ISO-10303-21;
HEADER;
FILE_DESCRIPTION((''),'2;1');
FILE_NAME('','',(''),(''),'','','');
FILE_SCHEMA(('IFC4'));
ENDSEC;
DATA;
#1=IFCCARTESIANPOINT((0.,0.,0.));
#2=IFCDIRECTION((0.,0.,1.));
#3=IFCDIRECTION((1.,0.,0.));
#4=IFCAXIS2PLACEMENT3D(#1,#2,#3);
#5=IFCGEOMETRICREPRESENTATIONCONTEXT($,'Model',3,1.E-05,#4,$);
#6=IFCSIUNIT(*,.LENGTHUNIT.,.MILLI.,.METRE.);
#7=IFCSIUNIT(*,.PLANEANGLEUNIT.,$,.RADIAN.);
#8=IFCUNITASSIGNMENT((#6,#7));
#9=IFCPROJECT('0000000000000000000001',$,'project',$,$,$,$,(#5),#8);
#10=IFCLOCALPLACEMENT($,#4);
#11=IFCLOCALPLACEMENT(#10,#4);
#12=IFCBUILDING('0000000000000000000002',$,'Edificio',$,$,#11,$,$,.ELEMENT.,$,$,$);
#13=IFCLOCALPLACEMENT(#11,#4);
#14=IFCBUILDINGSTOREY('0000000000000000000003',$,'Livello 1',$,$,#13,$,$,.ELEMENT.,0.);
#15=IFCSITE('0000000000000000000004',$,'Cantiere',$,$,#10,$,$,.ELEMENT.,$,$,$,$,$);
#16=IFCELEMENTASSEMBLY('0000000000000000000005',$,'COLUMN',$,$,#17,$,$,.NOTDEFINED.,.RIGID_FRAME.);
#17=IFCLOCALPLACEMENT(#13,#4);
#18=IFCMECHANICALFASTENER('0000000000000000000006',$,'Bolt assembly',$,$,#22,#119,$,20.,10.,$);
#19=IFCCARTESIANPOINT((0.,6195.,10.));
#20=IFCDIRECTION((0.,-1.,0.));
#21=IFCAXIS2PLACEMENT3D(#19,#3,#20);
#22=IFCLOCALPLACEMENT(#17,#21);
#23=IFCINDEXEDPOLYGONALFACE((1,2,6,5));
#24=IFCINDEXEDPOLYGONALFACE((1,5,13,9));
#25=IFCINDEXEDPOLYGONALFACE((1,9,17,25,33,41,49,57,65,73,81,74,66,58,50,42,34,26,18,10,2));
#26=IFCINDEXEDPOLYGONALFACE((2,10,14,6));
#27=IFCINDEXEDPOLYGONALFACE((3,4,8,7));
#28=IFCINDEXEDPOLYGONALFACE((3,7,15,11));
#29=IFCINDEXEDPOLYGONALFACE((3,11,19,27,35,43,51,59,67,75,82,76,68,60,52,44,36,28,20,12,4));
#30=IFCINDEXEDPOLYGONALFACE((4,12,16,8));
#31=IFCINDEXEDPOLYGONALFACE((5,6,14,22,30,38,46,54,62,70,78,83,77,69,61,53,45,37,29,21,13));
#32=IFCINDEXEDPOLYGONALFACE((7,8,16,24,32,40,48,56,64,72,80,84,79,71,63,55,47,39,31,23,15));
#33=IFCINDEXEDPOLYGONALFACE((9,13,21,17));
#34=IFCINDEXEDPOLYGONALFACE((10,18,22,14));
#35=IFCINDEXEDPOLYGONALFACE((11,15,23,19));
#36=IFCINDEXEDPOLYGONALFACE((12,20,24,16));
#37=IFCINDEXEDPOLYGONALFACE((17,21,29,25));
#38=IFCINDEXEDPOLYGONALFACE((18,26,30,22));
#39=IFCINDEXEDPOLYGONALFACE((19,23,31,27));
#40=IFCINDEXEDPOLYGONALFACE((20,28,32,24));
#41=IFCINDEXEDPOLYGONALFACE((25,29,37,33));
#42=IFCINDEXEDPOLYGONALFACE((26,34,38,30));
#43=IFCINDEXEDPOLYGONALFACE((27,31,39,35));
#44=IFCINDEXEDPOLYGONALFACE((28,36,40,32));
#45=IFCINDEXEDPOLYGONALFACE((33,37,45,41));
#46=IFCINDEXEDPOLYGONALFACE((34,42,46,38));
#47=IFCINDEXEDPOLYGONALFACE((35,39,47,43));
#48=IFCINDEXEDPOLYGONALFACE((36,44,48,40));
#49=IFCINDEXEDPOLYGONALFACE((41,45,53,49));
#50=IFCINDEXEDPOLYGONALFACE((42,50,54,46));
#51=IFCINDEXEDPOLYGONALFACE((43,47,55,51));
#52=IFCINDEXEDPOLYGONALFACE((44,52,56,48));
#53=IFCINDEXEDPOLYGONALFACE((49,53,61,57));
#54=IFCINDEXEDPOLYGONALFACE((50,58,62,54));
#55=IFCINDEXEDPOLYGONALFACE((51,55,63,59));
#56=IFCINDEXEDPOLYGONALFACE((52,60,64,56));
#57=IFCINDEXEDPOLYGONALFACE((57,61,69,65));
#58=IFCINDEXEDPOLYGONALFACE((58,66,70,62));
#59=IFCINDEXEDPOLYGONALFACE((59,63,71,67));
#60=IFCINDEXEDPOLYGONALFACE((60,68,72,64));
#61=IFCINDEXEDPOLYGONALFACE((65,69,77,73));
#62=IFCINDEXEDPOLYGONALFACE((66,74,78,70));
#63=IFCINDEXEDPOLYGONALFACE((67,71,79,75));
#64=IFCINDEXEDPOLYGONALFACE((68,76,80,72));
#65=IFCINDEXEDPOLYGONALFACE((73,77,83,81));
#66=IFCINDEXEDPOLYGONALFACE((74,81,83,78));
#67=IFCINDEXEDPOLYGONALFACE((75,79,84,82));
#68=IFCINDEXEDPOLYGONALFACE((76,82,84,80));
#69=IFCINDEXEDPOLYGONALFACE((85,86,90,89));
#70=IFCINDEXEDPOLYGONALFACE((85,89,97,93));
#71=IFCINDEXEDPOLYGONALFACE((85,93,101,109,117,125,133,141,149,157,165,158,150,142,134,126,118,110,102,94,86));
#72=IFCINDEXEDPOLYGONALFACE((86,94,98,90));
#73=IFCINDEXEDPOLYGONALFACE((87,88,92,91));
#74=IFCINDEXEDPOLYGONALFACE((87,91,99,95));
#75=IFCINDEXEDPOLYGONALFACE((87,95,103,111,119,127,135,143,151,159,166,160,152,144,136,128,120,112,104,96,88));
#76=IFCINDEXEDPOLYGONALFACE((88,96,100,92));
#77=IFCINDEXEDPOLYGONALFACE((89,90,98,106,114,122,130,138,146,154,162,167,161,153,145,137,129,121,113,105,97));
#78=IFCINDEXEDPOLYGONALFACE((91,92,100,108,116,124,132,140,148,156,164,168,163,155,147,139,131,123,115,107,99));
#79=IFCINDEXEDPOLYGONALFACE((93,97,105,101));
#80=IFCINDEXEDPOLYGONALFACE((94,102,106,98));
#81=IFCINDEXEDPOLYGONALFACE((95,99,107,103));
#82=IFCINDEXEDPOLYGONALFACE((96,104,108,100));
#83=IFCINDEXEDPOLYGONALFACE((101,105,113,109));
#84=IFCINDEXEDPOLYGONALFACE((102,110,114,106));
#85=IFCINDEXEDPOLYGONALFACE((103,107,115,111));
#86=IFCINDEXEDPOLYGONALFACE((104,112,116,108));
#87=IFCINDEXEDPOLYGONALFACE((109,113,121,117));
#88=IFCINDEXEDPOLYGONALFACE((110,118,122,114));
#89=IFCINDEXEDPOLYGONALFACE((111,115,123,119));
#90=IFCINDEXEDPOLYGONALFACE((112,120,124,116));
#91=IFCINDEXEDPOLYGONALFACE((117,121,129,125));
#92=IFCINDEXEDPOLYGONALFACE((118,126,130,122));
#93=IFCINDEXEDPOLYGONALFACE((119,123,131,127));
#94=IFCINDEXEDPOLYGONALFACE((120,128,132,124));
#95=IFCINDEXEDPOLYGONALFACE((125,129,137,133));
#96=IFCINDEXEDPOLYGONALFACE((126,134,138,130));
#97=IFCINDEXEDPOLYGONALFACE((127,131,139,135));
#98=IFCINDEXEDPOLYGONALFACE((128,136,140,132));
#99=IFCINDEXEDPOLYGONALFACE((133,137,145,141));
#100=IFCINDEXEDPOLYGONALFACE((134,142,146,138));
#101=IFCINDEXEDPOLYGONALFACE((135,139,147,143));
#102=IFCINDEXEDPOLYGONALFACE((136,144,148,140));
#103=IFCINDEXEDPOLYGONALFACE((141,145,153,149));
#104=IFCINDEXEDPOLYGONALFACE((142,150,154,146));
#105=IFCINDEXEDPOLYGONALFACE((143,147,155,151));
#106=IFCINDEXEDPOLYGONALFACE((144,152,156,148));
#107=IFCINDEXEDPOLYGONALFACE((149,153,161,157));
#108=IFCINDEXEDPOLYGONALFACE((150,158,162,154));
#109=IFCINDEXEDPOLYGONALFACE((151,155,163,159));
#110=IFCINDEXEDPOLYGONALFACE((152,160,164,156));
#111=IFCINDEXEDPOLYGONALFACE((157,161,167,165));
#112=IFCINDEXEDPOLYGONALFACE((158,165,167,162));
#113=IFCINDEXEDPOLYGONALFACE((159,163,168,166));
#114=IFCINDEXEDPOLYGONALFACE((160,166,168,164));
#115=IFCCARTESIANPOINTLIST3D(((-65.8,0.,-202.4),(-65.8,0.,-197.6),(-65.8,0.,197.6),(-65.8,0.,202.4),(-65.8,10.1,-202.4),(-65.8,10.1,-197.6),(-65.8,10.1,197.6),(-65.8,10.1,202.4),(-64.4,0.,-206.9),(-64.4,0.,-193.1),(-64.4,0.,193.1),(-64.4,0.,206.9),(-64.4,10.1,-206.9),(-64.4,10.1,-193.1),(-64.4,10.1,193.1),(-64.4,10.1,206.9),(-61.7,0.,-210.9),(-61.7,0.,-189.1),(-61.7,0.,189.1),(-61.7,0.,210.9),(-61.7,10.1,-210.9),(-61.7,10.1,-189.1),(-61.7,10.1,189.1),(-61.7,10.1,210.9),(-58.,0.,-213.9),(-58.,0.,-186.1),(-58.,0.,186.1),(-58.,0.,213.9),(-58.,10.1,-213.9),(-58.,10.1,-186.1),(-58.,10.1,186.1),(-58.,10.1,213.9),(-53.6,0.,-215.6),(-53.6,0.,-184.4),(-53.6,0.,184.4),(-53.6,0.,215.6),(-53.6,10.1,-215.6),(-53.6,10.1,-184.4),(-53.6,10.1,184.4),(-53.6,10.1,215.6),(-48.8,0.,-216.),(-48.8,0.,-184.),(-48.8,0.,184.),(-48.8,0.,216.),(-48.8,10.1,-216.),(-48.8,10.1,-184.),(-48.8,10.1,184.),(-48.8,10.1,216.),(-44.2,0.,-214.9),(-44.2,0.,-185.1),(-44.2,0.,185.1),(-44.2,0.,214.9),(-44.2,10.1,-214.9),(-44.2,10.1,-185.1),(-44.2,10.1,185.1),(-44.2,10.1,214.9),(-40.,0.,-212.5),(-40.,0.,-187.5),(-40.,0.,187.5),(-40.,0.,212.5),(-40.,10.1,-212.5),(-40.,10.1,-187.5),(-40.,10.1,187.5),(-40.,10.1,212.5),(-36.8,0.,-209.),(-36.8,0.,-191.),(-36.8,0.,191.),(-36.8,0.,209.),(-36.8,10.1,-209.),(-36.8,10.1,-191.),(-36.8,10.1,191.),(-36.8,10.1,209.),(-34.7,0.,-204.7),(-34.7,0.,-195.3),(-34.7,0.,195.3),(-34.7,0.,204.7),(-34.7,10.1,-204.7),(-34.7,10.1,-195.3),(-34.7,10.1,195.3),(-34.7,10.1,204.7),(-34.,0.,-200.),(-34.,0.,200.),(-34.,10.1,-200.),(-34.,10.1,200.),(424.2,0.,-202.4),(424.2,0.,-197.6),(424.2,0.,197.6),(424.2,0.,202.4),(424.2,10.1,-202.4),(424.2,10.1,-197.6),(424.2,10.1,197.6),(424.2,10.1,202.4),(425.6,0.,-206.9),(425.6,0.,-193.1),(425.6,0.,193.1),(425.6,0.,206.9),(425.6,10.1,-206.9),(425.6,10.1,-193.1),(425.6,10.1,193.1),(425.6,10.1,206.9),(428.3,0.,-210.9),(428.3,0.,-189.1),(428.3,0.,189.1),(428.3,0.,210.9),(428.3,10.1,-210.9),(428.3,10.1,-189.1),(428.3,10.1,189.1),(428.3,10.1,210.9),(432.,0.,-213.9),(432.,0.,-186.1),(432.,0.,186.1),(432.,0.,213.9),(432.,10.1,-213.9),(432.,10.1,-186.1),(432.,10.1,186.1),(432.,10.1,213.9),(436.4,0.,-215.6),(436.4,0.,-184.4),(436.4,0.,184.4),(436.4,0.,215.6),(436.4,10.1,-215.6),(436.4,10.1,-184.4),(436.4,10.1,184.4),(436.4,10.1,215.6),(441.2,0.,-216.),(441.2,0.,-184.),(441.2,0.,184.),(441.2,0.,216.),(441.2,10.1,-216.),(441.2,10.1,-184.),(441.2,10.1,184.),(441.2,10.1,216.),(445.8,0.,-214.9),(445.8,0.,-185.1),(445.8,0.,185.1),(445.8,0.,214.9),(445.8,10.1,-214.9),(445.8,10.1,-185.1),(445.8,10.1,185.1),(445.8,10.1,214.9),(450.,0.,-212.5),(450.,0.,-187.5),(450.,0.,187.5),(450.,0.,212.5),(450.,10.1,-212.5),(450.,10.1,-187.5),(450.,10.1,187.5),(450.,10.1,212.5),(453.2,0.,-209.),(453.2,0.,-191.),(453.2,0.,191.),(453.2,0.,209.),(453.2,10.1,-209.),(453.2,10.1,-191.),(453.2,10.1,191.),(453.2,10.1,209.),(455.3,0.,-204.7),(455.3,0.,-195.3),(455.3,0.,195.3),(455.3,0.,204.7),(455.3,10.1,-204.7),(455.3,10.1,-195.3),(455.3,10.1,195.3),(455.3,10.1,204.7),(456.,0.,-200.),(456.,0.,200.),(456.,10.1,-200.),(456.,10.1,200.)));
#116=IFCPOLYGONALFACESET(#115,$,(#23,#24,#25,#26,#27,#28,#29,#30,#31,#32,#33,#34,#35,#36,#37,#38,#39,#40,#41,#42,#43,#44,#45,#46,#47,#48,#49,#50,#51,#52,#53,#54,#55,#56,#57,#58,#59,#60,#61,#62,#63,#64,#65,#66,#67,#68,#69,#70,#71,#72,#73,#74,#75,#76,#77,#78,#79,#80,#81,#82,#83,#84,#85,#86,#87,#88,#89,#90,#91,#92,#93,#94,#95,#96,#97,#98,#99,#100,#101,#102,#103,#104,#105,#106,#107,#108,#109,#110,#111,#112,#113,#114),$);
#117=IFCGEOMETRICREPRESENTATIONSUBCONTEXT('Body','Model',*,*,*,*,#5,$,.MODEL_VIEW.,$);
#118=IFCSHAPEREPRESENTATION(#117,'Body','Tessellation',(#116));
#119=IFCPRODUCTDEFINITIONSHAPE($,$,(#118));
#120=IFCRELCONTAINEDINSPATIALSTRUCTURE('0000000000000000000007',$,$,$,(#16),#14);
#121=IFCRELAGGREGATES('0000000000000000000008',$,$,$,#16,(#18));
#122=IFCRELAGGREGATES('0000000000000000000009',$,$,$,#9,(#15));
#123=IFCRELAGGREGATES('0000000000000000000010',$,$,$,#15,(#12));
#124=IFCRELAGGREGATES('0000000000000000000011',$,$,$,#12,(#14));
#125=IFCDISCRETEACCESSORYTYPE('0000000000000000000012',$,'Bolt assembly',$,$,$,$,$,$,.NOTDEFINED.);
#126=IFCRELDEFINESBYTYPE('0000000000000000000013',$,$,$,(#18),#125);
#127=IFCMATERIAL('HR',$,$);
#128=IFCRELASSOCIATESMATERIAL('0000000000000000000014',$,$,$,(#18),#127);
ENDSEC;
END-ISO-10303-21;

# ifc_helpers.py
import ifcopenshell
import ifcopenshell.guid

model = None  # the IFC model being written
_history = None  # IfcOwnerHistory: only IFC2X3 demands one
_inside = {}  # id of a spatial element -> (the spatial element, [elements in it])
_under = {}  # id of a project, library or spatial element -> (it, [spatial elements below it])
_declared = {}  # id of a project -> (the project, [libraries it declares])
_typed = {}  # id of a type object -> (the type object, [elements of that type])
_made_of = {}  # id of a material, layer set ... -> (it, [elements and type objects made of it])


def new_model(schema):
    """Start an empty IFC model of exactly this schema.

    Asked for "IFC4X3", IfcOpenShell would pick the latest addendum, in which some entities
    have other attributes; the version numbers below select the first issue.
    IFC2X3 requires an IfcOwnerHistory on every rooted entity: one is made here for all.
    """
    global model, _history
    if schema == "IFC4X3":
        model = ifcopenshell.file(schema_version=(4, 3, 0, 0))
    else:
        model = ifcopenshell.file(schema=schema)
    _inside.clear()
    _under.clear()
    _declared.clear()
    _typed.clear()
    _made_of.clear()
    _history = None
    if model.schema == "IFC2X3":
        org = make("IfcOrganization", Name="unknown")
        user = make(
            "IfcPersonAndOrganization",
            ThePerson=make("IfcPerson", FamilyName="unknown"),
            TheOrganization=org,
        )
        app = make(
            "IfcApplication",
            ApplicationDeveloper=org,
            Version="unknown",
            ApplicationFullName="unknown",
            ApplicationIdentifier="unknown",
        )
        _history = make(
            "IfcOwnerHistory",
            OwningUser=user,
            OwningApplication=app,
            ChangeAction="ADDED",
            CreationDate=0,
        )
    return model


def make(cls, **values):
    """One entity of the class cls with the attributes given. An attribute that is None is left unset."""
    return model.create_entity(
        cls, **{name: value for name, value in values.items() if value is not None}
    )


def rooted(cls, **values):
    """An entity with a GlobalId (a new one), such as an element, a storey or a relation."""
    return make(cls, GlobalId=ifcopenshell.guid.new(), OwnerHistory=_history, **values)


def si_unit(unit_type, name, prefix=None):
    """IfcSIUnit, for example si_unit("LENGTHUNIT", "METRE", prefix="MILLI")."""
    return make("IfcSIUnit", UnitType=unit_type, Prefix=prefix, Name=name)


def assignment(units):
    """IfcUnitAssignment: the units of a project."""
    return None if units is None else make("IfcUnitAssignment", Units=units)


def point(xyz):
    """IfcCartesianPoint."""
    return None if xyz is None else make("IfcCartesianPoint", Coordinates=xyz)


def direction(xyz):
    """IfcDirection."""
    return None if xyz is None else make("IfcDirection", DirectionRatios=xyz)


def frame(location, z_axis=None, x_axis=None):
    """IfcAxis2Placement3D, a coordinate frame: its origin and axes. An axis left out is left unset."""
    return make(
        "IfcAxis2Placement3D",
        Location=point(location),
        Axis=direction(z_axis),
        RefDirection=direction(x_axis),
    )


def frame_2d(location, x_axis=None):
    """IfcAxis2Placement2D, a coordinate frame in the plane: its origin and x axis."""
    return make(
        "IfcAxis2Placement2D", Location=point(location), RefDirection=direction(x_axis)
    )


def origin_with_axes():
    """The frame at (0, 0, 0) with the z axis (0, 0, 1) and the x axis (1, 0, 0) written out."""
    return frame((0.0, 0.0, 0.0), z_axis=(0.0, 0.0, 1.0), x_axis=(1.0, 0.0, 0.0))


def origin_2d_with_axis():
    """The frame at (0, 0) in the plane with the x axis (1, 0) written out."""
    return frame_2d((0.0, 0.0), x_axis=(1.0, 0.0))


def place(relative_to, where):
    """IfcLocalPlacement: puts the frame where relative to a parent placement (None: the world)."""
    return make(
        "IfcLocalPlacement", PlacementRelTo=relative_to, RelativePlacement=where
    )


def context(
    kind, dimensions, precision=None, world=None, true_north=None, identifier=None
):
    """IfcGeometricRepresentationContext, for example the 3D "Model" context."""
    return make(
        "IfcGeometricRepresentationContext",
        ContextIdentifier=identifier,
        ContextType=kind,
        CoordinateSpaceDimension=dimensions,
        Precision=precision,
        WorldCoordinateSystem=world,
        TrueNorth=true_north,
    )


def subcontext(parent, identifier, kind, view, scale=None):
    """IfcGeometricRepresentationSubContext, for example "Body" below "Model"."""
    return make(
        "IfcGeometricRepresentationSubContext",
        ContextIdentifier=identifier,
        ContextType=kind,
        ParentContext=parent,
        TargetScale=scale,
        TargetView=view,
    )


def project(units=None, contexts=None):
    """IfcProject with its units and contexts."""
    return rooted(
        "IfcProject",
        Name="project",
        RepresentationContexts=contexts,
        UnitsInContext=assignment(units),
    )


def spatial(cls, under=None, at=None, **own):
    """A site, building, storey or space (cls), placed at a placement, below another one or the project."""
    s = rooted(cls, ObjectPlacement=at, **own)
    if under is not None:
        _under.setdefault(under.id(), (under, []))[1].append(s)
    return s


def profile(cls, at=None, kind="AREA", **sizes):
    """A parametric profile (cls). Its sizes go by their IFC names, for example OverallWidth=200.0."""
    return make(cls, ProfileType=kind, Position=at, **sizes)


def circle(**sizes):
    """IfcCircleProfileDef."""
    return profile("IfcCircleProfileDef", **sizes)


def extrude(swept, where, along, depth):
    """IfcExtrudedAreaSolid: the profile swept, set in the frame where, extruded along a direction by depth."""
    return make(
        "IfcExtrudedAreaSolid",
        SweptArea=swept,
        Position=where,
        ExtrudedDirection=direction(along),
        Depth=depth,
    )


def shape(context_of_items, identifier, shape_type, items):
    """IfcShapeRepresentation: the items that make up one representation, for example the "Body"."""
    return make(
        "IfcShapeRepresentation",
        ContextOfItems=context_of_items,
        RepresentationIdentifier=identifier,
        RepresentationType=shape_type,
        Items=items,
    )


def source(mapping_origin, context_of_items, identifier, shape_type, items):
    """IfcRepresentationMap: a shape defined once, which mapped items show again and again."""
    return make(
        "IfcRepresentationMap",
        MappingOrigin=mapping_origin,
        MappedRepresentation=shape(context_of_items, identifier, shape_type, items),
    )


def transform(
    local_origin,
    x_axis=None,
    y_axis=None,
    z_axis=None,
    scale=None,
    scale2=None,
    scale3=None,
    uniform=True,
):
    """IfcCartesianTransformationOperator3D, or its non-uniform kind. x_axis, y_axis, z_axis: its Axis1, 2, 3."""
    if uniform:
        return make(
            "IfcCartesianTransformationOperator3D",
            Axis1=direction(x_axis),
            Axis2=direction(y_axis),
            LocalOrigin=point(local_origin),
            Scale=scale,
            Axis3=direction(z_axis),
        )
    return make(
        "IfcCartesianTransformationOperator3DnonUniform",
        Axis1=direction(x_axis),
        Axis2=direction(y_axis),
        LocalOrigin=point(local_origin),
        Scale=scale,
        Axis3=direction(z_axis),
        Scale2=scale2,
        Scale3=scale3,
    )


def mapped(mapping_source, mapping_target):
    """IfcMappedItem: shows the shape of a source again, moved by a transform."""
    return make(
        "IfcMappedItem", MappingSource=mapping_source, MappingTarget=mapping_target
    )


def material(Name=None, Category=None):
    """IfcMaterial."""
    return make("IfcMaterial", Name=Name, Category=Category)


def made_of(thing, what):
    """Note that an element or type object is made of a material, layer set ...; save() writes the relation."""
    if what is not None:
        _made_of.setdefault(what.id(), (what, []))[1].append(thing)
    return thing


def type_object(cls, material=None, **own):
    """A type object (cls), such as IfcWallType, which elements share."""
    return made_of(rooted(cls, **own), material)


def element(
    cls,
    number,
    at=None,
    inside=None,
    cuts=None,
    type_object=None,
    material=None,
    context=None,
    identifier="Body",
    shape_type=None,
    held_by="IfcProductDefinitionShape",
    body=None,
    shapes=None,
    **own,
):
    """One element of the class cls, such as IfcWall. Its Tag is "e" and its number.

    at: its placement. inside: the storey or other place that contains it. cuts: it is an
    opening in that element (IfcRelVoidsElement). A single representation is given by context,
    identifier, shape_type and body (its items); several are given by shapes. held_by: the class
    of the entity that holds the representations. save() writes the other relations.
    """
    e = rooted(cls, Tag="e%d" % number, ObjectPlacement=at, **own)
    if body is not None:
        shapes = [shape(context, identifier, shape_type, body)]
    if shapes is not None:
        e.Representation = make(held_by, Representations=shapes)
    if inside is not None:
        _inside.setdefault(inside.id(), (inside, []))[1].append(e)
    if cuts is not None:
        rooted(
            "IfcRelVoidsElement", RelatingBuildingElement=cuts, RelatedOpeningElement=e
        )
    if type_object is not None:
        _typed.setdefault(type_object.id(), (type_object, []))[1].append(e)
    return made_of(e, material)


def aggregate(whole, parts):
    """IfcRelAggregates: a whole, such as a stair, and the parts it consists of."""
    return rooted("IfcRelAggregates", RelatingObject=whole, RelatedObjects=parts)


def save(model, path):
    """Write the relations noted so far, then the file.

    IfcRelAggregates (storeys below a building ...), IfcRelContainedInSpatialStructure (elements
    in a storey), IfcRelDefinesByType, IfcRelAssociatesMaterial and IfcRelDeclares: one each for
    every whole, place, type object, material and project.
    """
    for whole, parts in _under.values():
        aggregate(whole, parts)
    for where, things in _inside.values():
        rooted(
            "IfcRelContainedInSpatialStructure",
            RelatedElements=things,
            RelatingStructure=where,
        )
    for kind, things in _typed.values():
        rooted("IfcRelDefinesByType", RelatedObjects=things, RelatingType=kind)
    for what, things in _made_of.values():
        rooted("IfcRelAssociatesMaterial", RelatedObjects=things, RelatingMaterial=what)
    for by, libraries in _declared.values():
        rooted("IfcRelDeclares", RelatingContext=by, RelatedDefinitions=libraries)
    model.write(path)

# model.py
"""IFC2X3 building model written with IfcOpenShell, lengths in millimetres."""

from ifc_helpers import new_model, si_unit, frame, origin_with_axes, origin_2d_with_axis, place, context, subcontext, project, spatial, circle, extrude, source, transform, mapped, material, type_object, element, aggregate, save


model = new_model("IFC2X3")

# Units and contexts
model_context = context("Model", 3, precision=1e-05, world=origin_with_axes())
body_context = subcontext(model_context, "Body", "Model", "MODEL_VIEW")
ifc_project = project(units=[si_unit("LENGTHUNIT", "METRE", prefix="MILLI"), si_unit("PLANEANGLEUNIT", "RADIAN")], contexts=[model_context])

# Site, building, storey
site_placement = place(None, origin_with_axes())
site = spatial("IfcSite", under=ifc_project, at=site_placement, Name="Cantiere", CompositionType="ELEMENT")
building_placement = place(site_placement, origin_with_axes())
building = spatial("IfcBuilding", under=site, at=building_placement, Name="Edificio", CompositionType="ELEMENT")
storey_placement = place(building_placement, origin_with_axes())
storey = spatial("IfcBuildingStorey", under=building, at=storey_placement, Name="Livello 1", CompositionType="ELEMENT", Elevation=0.0)

# Element assembly
assembly_1_placement = place(storey_placement, origin_with_axes())
assembly_1 = element("IfcElementAssembly", 1, at=assembly_1_placement, inside=storey, Name="COLUMN", AssemblyPlace="NOTDEFINED", PredefinedType="RIGID_FRAME")

# Mechanical fastener
ifc_material_1 = material(Name="HR")
discrete_accessory_type_1 = type_object("IfcDiscreteAccessoryType", Name="Bolt assembly")
shared_shape_1 = source(origin_with_axes(), body_context, "Body", "SweptSolid", [
    extrude(circle(Radius=16.0, at=origin_2d_with_axis()), frame((0.0, 0.0, 0.0), z_axis=(0.0, 1.0, 0.0), x_axis=(1.0, 0.0, 0.0)), (0.0, 0.0, 1.0), 10.1),
])
mechanical_fastener_1_placement = place(assembly_1_placement, frame((0.0, 6195.0, 10.0), z_axis=(1.0, 0.0, 0.0), x_axis=(0.0, -1.0, 0.0)))
mechanical_fastener_1 = element("IfcMechanicalFastener", 2, at=mechanical_fastener_1_placement, type_object=discrete_accessory_type_1, material=ifc_material_1, Name="Bolt assembly", NominalDiameter=20.0, NominalLength=10.0, context=body_context, shape_type="MappedRepresentation", body=[
    mapped(shared_shape_1, transform((-50.0, 0.0, -200.0))),
    mapped(shared_shape_1, transform((-50.0, 0.0, 200.0))),
    mapped(shared_shape_1, transform((440.0, 0.0, -200.0))),
    mapped(shared_shape_1, transform((440.0, 0.0, 200.0))),
])

aggregate(assembly_1, [mechanical_fastener_1])

save(model, "model.ifc")
